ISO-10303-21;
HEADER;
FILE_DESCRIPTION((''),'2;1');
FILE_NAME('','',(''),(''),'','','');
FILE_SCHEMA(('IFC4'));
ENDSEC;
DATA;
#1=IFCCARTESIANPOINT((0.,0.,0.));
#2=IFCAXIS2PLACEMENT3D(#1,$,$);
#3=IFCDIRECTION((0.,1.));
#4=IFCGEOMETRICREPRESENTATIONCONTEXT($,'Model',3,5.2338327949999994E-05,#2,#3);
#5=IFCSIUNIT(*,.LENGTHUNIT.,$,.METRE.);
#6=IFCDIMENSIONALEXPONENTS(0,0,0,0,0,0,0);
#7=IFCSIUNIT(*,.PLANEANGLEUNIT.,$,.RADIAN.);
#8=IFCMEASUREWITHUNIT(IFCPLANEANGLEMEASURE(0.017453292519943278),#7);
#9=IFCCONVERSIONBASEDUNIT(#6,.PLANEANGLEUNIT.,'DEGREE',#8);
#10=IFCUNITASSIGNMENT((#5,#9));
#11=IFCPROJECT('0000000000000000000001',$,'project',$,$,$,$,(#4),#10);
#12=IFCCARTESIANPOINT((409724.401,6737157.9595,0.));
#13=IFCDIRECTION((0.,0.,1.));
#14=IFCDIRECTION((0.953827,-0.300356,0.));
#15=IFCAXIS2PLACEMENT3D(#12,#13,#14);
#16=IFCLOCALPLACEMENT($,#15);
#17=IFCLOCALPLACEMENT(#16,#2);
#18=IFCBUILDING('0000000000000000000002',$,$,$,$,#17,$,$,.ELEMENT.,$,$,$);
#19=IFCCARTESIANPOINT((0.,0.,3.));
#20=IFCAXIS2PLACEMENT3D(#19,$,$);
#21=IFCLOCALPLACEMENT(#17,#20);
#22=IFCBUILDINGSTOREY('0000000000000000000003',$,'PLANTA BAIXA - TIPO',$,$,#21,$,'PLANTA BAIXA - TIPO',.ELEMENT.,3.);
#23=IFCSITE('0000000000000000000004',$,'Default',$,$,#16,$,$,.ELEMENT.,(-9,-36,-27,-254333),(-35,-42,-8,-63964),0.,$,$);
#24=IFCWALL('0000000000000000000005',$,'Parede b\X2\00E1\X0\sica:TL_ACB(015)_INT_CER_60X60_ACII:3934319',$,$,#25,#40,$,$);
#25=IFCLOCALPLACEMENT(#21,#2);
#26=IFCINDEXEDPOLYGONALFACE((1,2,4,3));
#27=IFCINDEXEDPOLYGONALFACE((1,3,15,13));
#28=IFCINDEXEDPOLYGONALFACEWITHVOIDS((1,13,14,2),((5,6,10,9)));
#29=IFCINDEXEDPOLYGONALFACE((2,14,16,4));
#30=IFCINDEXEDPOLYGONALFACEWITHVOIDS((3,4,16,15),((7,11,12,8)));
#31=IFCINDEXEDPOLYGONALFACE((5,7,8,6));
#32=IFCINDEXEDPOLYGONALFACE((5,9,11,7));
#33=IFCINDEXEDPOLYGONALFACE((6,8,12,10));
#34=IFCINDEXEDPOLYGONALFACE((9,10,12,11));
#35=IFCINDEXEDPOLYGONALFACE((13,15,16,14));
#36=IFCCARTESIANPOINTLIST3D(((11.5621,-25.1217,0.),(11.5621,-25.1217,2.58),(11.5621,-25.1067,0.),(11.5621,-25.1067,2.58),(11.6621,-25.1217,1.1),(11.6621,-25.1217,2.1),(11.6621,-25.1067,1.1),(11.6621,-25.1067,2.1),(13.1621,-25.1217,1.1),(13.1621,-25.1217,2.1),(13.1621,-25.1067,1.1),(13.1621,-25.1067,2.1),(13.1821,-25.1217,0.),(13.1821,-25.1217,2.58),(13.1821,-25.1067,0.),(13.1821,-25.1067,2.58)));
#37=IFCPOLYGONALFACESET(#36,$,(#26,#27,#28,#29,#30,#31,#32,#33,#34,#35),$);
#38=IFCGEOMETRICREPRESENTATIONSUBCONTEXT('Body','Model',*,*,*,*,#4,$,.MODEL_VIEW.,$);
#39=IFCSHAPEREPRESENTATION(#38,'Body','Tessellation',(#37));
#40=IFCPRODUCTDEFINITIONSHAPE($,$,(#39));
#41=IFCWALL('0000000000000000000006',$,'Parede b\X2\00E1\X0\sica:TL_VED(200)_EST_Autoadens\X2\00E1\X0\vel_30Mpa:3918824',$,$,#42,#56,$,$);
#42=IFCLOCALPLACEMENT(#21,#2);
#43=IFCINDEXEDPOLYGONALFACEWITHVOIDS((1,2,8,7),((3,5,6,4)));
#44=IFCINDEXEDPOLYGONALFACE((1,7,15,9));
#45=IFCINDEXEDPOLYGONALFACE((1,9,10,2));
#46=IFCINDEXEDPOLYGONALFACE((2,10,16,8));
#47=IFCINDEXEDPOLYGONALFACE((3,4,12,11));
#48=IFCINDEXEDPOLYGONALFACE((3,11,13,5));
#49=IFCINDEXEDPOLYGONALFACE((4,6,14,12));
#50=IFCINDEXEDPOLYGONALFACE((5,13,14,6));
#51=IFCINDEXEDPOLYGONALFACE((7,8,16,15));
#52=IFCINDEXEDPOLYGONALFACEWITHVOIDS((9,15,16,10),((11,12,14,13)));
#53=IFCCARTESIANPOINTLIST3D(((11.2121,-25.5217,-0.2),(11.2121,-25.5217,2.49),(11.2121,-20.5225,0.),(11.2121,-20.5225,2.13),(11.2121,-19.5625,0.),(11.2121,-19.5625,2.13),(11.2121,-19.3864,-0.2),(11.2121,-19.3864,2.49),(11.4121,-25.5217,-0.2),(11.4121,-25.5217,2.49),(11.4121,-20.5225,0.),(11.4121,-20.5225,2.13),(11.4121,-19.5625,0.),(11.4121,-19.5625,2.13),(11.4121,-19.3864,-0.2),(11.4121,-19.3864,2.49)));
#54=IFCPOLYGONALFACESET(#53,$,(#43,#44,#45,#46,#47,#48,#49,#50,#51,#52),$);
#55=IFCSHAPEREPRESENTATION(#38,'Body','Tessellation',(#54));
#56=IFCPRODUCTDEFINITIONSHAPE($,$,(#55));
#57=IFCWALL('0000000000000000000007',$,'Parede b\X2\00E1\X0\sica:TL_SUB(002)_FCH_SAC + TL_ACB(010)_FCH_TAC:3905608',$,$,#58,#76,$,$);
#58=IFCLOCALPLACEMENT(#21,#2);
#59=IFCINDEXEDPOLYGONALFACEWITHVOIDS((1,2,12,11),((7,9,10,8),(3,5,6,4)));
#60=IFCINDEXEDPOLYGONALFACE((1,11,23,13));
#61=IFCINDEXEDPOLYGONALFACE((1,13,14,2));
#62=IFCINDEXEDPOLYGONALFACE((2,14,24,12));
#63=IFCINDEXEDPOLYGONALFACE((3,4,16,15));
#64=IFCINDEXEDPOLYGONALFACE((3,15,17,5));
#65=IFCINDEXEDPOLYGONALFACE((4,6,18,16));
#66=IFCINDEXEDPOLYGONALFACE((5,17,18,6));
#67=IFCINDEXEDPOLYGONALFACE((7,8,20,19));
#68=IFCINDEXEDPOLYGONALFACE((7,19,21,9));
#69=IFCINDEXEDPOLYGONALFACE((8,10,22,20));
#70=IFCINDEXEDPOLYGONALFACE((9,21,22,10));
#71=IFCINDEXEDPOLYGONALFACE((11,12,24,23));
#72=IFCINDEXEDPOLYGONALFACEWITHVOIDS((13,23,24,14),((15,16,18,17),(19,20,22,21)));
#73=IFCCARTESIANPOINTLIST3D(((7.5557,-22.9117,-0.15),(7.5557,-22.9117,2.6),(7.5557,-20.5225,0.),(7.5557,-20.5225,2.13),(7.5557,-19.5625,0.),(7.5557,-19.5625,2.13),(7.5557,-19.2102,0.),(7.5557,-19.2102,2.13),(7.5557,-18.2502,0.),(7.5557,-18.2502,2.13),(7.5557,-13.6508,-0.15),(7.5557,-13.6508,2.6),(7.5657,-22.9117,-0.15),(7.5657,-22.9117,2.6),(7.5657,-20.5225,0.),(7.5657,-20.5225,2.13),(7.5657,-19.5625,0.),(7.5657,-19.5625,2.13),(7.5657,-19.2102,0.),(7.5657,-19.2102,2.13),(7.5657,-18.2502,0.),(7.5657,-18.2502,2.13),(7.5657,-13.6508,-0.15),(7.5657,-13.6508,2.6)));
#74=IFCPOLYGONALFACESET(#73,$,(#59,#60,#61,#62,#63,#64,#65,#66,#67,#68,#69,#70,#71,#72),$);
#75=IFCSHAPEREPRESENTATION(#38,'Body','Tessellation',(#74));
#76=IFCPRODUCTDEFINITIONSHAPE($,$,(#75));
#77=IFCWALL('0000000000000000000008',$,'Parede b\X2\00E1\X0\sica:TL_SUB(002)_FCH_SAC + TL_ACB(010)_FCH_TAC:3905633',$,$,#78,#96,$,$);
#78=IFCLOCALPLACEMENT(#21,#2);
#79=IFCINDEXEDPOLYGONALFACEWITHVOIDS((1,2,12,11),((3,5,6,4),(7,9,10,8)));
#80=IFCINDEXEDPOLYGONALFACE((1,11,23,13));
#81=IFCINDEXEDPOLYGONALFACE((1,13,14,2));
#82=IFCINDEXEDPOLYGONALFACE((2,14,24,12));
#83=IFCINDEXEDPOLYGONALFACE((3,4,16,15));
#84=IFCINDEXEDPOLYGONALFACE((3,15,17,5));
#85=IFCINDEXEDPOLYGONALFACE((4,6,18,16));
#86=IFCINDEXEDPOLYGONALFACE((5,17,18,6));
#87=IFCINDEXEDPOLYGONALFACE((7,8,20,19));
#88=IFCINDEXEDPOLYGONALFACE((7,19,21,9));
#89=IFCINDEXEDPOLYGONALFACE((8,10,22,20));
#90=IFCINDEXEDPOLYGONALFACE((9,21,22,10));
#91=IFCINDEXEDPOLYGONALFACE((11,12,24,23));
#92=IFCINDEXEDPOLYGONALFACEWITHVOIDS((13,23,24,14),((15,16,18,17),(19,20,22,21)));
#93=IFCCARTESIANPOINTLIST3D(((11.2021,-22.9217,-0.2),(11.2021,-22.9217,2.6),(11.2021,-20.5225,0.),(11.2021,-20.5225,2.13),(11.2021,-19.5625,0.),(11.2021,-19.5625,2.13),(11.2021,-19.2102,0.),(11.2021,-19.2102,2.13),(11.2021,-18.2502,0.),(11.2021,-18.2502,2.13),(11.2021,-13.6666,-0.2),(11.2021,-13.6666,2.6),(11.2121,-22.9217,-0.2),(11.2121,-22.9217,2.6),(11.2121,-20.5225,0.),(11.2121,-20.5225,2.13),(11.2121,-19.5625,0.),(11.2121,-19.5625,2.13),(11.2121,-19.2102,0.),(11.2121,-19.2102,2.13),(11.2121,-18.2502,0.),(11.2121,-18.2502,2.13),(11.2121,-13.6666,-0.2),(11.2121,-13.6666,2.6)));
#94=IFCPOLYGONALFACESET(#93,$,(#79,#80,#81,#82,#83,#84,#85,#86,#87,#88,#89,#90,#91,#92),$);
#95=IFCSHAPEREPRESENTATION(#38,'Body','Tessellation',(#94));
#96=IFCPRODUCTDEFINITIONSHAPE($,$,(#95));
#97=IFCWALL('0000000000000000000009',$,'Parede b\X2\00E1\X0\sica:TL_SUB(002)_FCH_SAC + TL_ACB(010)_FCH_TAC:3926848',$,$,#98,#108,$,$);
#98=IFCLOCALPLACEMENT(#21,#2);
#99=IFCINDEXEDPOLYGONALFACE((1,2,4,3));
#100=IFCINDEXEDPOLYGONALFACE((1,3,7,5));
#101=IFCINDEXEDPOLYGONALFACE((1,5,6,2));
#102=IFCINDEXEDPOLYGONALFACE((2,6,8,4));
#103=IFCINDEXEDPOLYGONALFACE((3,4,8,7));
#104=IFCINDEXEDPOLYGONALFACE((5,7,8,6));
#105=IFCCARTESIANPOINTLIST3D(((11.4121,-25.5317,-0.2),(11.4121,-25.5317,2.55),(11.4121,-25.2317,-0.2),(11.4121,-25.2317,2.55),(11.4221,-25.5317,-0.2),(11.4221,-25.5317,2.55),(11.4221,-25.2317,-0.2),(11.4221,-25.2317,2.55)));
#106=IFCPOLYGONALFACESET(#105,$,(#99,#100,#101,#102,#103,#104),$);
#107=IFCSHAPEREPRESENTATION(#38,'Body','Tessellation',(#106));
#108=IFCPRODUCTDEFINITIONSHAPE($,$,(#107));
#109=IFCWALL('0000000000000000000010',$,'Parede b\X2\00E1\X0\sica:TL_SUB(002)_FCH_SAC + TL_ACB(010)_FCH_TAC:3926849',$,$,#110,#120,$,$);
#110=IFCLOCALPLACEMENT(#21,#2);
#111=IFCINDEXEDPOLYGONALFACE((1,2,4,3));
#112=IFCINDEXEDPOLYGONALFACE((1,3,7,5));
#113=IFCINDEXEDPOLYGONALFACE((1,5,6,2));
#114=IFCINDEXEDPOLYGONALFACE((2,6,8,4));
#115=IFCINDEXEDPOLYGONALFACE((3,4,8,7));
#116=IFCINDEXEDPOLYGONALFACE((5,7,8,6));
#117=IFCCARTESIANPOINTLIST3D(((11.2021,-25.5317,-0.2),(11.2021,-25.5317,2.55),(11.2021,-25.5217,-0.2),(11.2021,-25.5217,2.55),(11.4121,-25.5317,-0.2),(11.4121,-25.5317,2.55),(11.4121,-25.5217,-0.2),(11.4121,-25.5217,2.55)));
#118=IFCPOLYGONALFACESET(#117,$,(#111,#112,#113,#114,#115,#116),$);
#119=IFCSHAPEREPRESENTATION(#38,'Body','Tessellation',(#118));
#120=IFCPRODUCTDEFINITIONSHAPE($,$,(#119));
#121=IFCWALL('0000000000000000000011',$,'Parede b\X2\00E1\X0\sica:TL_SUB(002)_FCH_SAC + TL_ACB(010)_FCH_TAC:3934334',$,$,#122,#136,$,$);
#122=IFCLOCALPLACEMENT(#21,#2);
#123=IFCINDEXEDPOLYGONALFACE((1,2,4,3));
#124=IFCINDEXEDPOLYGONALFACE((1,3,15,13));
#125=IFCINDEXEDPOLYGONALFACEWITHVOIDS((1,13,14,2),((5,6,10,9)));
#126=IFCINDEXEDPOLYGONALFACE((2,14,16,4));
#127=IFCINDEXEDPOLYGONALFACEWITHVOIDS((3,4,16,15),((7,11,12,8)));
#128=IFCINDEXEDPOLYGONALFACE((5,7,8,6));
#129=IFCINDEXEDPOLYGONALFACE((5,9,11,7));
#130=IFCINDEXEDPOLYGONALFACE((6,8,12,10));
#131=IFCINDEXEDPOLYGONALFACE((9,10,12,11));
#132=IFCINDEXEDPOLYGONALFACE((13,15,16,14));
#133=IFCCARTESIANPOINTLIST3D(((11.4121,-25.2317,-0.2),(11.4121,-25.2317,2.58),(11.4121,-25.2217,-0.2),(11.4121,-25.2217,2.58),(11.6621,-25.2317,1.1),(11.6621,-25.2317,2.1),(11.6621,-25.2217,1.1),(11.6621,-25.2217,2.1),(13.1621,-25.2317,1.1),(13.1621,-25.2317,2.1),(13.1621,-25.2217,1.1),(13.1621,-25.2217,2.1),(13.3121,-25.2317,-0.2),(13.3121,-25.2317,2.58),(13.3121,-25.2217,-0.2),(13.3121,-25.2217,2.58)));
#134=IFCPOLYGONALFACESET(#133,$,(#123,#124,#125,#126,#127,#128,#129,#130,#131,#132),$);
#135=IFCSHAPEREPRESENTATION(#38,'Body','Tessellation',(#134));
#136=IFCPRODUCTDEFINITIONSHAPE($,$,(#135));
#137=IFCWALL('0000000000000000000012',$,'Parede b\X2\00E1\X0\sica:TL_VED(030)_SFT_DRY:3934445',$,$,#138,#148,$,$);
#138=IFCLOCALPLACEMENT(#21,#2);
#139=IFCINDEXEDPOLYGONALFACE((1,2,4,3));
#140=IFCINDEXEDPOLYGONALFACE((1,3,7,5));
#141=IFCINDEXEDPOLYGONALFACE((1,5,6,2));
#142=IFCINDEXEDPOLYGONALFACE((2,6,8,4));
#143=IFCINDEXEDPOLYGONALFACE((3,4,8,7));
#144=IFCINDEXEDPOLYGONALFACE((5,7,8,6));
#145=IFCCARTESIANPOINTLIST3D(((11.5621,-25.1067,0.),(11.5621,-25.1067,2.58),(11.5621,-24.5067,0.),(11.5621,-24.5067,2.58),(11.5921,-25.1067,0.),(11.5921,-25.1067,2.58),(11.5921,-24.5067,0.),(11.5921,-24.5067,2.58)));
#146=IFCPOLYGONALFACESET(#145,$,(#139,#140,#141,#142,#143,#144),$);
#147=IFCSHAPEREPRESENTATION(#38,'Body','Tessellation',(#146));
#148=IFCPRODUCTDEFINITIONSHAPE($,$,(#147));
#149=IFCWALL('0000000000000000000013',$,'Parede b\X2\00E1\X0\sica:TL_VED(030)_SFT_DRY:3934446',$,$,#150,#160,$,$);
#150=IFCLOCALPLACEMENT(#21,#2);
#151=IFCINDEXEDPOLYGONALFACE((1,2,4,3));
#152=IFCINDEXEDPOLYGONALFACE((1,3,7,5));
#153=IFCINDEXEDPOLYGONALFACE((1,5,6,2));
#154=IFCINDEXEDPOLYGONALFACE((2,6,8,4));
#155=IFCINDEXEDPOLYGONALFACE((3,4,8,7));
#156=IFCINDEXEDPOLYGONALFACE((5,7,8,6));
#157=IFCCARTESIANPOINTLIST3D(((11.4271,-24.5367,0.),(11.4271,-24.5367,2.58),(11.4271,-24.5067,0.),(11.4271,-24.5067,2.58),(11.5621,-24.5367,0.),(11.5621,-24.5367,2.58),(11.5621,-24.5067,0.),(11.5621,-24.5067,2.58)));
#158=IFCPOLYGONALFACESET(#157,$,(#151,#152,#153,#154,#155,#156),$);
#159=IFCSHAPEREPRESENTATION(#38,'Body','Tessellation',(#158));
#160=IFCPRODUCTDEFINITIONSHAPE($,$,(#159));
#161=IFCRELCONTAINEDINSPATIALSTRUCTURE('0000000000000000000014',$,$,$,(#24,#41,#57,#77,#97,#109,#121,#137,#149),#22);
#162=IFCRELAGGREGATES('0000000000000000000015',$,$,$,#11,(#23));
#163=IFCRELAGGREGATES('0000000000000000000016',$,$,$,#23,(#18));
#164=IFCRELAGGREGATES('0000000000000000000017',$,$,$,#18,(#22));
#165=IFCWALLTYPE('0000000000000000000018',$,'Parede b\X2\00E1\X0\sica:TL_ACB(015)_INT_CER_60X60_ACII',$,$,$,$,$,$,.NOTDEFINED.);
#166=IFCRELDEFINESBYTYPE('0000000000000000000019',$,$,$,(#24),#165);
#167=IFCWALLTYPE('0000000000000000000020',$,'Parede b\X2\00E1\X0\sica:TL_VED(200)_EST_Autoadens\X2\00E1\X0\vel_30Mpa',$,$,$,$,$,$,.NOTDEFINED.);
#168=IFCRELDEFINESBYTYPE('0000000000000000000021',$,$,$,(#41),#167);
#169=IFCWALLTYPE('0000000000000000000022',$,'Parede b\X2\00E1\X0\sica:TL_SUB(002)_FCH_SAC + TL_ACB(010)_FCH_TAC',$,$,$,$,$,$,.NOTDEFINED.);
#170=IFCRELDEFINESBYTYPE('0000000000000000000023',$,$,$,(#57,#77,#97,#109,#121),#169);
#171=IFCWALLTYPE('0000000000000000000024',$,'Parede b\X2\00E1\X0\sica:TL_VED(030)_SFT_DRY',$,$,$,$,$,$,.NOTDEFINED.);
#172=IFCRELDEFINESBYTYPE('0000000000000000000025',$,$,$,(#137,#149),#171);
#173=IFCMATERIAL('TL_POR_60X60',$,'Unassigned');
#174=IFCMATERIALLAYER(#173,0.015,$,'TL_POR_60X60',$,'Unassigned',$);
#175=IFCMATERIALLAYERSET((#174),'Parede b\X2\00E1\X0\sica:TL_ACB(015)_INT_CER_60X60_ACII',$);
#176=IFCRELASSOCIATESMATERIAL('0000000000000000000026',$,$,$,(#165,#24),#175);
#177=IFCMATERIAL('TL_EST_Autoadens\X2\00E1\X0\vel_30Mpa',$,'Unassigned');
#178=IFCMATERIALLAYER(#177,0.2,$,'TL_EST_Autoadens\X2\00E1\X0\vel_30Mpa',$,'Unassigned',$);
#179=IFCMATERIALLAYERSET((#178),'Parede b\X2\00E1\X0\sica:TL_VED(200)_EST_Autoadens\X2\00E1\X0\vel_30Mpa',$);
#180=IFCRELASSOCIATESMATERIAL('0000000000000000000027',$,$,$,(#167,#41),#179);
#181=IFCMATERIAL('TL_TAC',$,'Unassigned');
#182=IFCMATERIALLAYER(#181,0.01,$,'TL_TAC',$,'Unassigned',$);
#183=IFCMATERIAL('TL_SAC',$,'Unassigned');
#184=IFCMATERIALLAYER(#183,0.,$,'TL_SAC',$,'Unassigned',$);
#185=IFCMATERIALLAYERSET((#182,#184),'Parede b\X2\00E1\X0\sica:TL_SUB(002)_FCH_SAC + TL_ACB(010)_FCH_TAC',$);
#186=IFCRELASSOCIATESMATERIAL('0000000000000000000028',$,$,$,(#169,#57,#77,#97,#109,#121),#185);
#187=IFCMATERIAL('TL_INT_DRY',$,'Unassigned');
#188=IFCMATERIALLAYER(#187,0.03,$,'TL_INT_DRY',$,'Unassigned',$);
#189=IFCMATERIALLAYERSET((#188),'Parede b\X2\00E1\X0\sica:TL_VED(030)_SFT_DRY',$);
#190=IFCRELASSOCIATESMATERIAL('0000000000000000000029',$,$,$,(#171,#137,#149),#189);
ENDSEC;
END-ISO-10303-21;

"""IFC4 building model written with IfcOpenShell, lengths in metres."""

from ifc_helpers import new_model, entity, si_unit, converted_unit, direction, frame, frame_2d, origin, place, context, subcontext, project, spatial, rectangle, extrude, material, layer, layer_set, layer_usage, type_object, element, save


model = new_model("IFC4")

# Units and contexts
model_context = context("Model", 3, precision=5.2338327949999994e-05, world=origin(), true_north=direction((0.0, 1.0)))
body_context = subcontext(model_context, "Body", "Model", "MODEL_VIEW")
ifc_project = project(units=[si_unit("LENGTHUNIT", "METRE"), converted_unit("PLANEANGLEUNIT", "DEGREE", entity("IfcPlaneAngleMeasure", 0.017453292519943278), si_unit("PLANEANGLEUNIT", "RADIAN"), dimensions=[0, 0, 0, 0, 0, 0, 0])], contexts=[model_context])

# Site, building, storey
site_placement = place(None, frame((409724.401, 6737157.9595, 0.0), z_axis=(0.0, 0.0, 1.0), x_axis=(0.953827, -0.300356, 0.0)))
site = spatial("IfcSite", under=ifc_project, at=site_placement, Name="Default", CompositionType="ELEMENT", RefLatitude=(-9, -36, -27, -254333), RefLongitude=(-35, -42, -8, -63964), RefElevation=0.0)
building_placement = place(site_placement, origin())
building = spatial("IfcBuilding", under=site, at=building_placement, CompositionType="ELEMENT")
storey_placement = place(building_placement, frame((0.0, 0.0, 3.0)))
storey = spatial("IfcBuildingStorey", under=building, at=storey_placement, Name="PLANTA BAIXA - TIPO", LongName="PLANTA BAIXA - TIPO", CompositionType="ELEMENT", Elevation=3.0)

# Shared definitions
ifc_material_1 = material(Name="TL_POR_60X60", Category="Unassigned")

# Shared definitions
ifc_material_2 = material(Name="TL_EST_Autoadensável_30Mpa", Category="Unassigned")

# Shared definitions
ifc_material_3 = material(Name="TL_SAC", Category="Unassigned")

# Shared definitions
ifc_layer_1 = layer(ifc_material_1, 0.015, Name="TL_POR_60X60", Category="Unassigned")
ifc_layer_set_1 = layer_set([ifc_layer_1], Name="Parede básica:TL_ACB(015)_INT_CER_60X60_ACII")
wall_type_1 = type_object("IfcWallType", Name="Parede básica:TL_ACB(015)_INT_CER_60X60_ACII", PredefinedType="NOTDEFINED", material=ifc_layer_set_1)

# Walls, openings
ifc_layer_usage_1 = layer_usage(ifc_layer_set_1, "AXIS2", "NEGATIVE", 0.0075)
wall_1_placement = place(storey_placement, frame((11.5621, -25.1142, 0.0)))
wall_1 = element("IfcWall", 1, at=wall_1_placement, inside=storey, type_object=wall_type_1, material=ifc_layer_usage_1, Name="Parede básica:TL_ACB(015)_INT_CER_60X60_ACII:3934319", context=body_context, shape_type="SweptSolid", body=[
    extrude(rectangle(XDim=1.62, YDim=0.015, at=frame_2d((0.81, 0.0), x_axis=(-1.0, 0.0))), origin(), (0.0, 0.0, 1.0), 2.58),
])
opening_1_placement = place(wall_1_placement, frame((-11.5621, 25.1142, 1.1)))
element("IfcOpeningElement", 2, at=opening_1_placement, cuts=wall_1, PredefinedType="OPENING", context=body_context, shape_type="SweptSolid", body=[
    extrude(rectangle(XDim=1.0, YDim=1.5, at=frame_2d((0.0, 0.0), x_axis=(0.0, 1.0))), frame((12.4121, -26.6457, 0.5), z_axis=(0.0, 1.0, 0.0), x_axis=(1.0, 0.0, 0.0)), (0.0, 0.0, 1.0), 3.048),
])
ifc_layer_2 = layer(ifc_material_2, 0.2, Name="TL_EST_Autoadensável_30Mpa", Category="Unassigned")
ifc_layer_set_2 = layer_set([ifc_layer_2], Name="Parede básica:TL_VED(200)_EST_Autoadensável_30Mpa")
ifc_layer_usage_2 = layer_usage(ifc_layer_set_2, "AXIS2", "NEGATIVE", 0.1)
wall_type_2 = type_object("IfcWallType", Name="Parede básica:TL_VED(200)_EST_Autoadensável_30Mpa", PredefinedType="NOTDEFINED", material=ifc_layer_set_2)
wall_2_placement = place(storey_placement, frame((11.3121, -25.5217, -0.2), z_axis=(0.0, 0.0, 1.0), x_axis=(0.0, 1.0, 0.0)))
wall_2 = element("IfcWall", 3, at=wall_2_placement, inside=storey, type_object=wall_type_2, material=ifc_layer_usage_2, Name="Parede básica:TL_VED(200)_EST_Autoadensável_30Mpa:3918824", context=body_context, shape_type="SweptSolid", body=[
    extrude(rectangle(XDim=6.1354, YDim=0.2, at=frame_2d((3.0677, 0.0), x_axis=(-1.0, 0.0))), origin(), (0.0, 0.0, 1.0), 2.69),
])
opening_2_placement = place(wall_2_placement, frame((5.9592, 0.1, 0.2)))
element("IfcOpeningElement", 4, at=opening_2_placement, cuts=wall_2, PredefinedType="OPENING", context=body_context, shape_type="SweptSolid", body=[
    extrude(rectangle(XDim=2.13, YDim=0.96, at=frame_2d((1.065, 0.48), x_axis=(1.0, 0.0))), frame((0.0, 0.0, 0.0), z_axis=(0.0, -1.0, 0.0), x_axis=(0.0, 0.0, 1.0)), (0.0, 0.0, 1.0), 0.2),
])

# Walls, openings
ifc_material_4 = material(Name="TL_TAC", Category="Unassigned")
ifc_layer_3 = layer(ifc_material_4, 0.01, Name="TL_TAC", Category="Unassigned")
ifc_layer_4 = layer(ifc_material_3, 0.0, Name="TL_SAC", Category="Unassigned")
ifc_layer_set_3 = layer_set([ifc_layer_3, ifc_layer_4], Name="Parede básica:TL_SUB(002)_FCH_SAC + TL_ACB(010)_FCH_TAC")
ifc_layer_usage_3 = layer_usage(ifc_layer_set_3, "AXIS2", "NEGATIVE", 0.005)
wall_type_3 = type_object("IfcWallType", Name="Parede básica:TL_SUB(002)_FCH_SAC + TL_ACB(010)_FCH_TAC", PredefinedType="NOTDEFINED", material=ifc_layer_set_3)
wall_3_placement = place(storey_placement, frame((7.5607, -22.9117, -0.15), z_axis=(0.0, 0.0, 1.0), x_axis=(0.0, 1.0, 0.0)))
wall_3 = element("IfcWall", 5, at=wall_3_placement, inside=storey, type_object=wall_type_3, material=ifc_layer_usage_3, Name="Parede básica:TL_SUB(002)_FCH_SAC + TL_ACB(010)_FCH_TAC:3905608", context=body_context, shape_type="SweptSolid", body=[
    extrude(rectangle(XDim=9.2609, YDim=0.01, at=frame_2d((4.6305, 0.0), x_axis=(-1.0, 0.0))), origin(), (0.0, 0.0, 1.0), 2.75),
])
opening_3_placement = place(wall_3_placement, frame((22.9117, 7.5607, 0.15)))
element("IfcOpeningElement", 6, at=opening_3_placement, cuts=wall_3, PredefinedType="OPENING", context=body_context, shape_type="SweptSolid", body=[
    extrude(rectangle(XDim=2.13, YDim=0.96, at=frame_2d((0.0, 0.0), x_axis=(1.0, 0.0))), frame((-20.0425, -8.8797, 1.065), z_axis=(0.0, 1.0, 0.0), x_axis=(0.0, 0.0, 1.0)), (0.0, 0.0, 1.0), 3.048),
])
opening_4_placement = place(wall_3_placement, frame((22.9117, 7.5607, 0.15)))
element("IfcOpeningElement", 7, at=opening_4_placement, cuts=wall_3, PredefinedType="OPENING", context=body_context, shape_type="SweptSolid", body=[
    extrude(rectangle(XDim=2.13, YDim=0.96, at=frame_2d((0.0, 0.0), x_axis=(0.0, 1.0))), frame((-18.7302, -8.8797, 1.065), z_axis=(0.0, 1.0, 0.0), x_axis=(-1.0, 0.0, 0.0)), (0.0, 0.0, 1.0), 3.048),
])
ifc_layer_usage_4 = layer_usage(ifc_layer_set_3, "AXIS2", "POSITIVE", -0.005)
wall_4_placement = place(storey_placement, frame((11.2071, -22.9217, -0.2), z_axis=(0.0, 0.0, 1.0), x_axis=(0.0, 1.0, 0.0)))
wall_4 = element("IfcWall", 8, at=wall_4_placement, inside=storey, type_object=wall_type_3, material=ifc_layer_usage_4, Name="Parede básica:TL_SUB(002)_FCH_SAC + TL_ACB(010)_FCH_TAC:3905633", context=body_context, shape_type="SweptSolid", body=[
    extrude(rectangle(XDim=9.2551, YDim=0.01, at=frame_2d((4.6276, 0.0), x_axis=(-1.0, 0.0))), origin(), (0.0, 0.0, 1.0), 2.8),
])
opening_5_placement = place(wall_4_placement, frame((22.9217, 11.2071, 0.2)))
element("IfcOpeningElement", 9, at=opening_5_placement, cuts=wall_4, PredefinedType="OPENING", context=body_context, shape_type="SweptSolid", body=[
    extrude(rectangle(XDim=2.13, YDim=0.96, at=frame_2d((0.0, 0.0), x_axis=(1.0, 0.0))), frame((-20.0425, -12.9361, 1.065), z_axis=(0.0, 1.0, 0.0), x_axis=(0.0, 0.0, 1.0)), (0.0, 0.0, 1.0), 3.048),
])
opening_6_placement = place(wall_4_placement, frame((22.9217, 11.2071, 0.2)))
element("IfcOpeningElement", 10, at=opening_6_placement, cuts=wall_4, PredefinedType="OPENING", context=body_context, shape_type="SweptSolid", body=[
    extrude(rectangle(XDim=2.13, YDim=0.96, at=frame_2d((0.0, 0.0), x_axis=(0.0, 1.0))), frame((-18.7302, -12.9361, 1.065), z_axis=(0.0, 1.0, 0.0), x_axis=(-1.0, 0.0, 0.0)), (0.0, 0.0, 1.0), 3.048),
])

# Walls
ifc_layer_usage_5 = layer_usage(ifc_layer_set_3, "AXIS2", "POSITIVE", -0.005)
wall_5_placement = place(storey_placement, frame((11.4171, -25.2317, -0.2), z_axis=(0.0, 0.0, 1.0), x_axis=(0.0, -1.0, 0.0)))
element("IfcWall", 11, at=wall_5_placement, inside=storey, type_object=wall_type_3, material=ifc_layer_usage_5, Name="Parede básica:TL_SUB(002)_FCH_SAC + TL_ACB(010)_FCH_TAC:3926848", context=body_context, shape_type="SweptSolid", body=[
    extrude(rectangle(XDim=0.3, YDim=0.01, at=frame_2d((0.15, 0.0), x_axis=(-1.0, 0.0))), origin(), (0.0, 0.0, 1.0), 2.75),
])
ifc_layer_usage_6 = layer_usage(ifc_layer_set_3, "AXIS2", "POSITIVE", -0.005)
wall_6_placement = place(storey_placement, frame((11.4121, -25.5267, -0.2), z_axis=(0.0, 0.0, 1.0), x_axis=(-1.0, 0.0, 0.0)))
element("IfcWall", 12, at=wall_6_placement, inside=storey, type_object=wall_type_3, material=ifc_layer_usage_6, Name="Parede básica:TL_SUB(002)_FCH_SAC + TL_ACB(010)_FCH_TAC:3926849", context=body_context, shape_type="SweptSolid", body=[
    extrude(rectangle(XDim=0.21, YDim=0.01, at=frame_2d((0.105, 0.0), x_axis=(-1.0, 0.0))), origin(), (0.0, 0.0, 1.0), 2.75),
])

# Wall, opening
ifc_layer_usage_7 = layer_usage(ifc_layer_set_3, "AXIS2", "NEGATIVE", 0.005)
wall_7_placement = place(storey_placement, frame((11.4121, -25.2267, -0.2)))
wall_7 = element("IfcWall", 13, at=wall_7_placement, inside=storey, type_object=wall_type_3, material=ifc_layer_usage_7, Name="Parede básica:TL_SUB(002)_FCH_SAC + TL_ACB(010)_FCH_TAC:3934334", context=body_context, shape_type="SweptSolid", body=[
    extrude(rectangle(XDim=1.9, YDim=0.01, at=frame_2d((0.95, 0.0), x_axis=(-1.0, 0.0))), origin(), (0.0, 0.0, 1.0), 2.78),
])
opening_7_placement = place(wall_7_placement, frame((-11.4121, 25.2267, 1.3)))
element("IfcOpeningElement", 14, at=opening_7_placement, cuts=wall_7, PredefinedType="OPENING", context=body_context, shape_type="SweptSolid", body=[
    extrude(rectangle(XDim=1.0, YDim=1.5, at=frame_2d((0.0, 0.0), x_axis=(0.0, 1.0))), frame((12.4121, -26.6457, 0.5), z_axis=(0.0, 1.0, 0.0), x_axis=(1.0, 0.0, 0.0)), (0.0, 0.0, 1.0), 3.048),
])

# Walls
ifc_material_5 = material(Name="TL_INT_DRY", Category="Unassigned")
ifc_layer_5 = layer(ifc_material_5, 0.03, Name="TL_INT_DRY", Category="Unassigned")
ifc_layer_set_4 = layer_set([ifc_layer_5], Name="Parede básica:TL_VED(030)_SFT_DRY")
ifc_layer_usage_8 = layer_usage(ifc_layer_set_4, "AXIS2", "POSITIVE", -0.015)
wall_type_4 = type_object("IfcWallType", Name="Parede básica:TL_VED(030)_SFT_DRY", PredefinedType="NOTDEFINED", material=ifc_layer_set_4)
wall_8_placement = place(storey_placement, frame((11.5771, -25.1067, 0.0), z_axis=(0.0, 0.0, 1.0), x_axis=(0.0, 1.0, 0.0)))
element("IfcWall", 15, at=wall_8_placement, inside=storey, type_object=wall_type_4, material=ifc_layer_usage_8, Name="Parede básica:TL_VED(030)_SFT_DRY:3934445", context=body_context, shape_type="SweptSolid", body=[
    extrude(rectangle(XDim=0.6, YDim=0.03, at=frame_2d((0.3, 0.0), x_axis=(-1.0, 0.0))), origin(), (0.0, 0.0, 1.0), 2.58),
])
ifc_layer_usage_9 = layer_usage(ifc_layer_set_4, "AXIS2", "POSITIVE", -0.015)
wall_9_placement = place(storey_placement, frame((11.5621, -24.5217, 0.0), z_axis=(0.0, 0.0, 1.0), x_axis=(-1.0, 0.0, 0.0)))
element("IfcWall", 16, at=wall_9_placement, inside=storey, type_object=wall_type_4, material=ifc_layer_usage_9, Name="Parede básica:TL_VED(030)_SFT_DRY:3934446", context=body_context, shape_type="SweptSolid", body=[
    extrude(rectangle(XDim=0.135, YDim=0.03, at=frame_2d((0.0675, 0.0), x_axis=(-1.0, 0.0))), origin(), (0.0, 0.0, 1.0), 2.58),
])

save(model, "model.ifc")
